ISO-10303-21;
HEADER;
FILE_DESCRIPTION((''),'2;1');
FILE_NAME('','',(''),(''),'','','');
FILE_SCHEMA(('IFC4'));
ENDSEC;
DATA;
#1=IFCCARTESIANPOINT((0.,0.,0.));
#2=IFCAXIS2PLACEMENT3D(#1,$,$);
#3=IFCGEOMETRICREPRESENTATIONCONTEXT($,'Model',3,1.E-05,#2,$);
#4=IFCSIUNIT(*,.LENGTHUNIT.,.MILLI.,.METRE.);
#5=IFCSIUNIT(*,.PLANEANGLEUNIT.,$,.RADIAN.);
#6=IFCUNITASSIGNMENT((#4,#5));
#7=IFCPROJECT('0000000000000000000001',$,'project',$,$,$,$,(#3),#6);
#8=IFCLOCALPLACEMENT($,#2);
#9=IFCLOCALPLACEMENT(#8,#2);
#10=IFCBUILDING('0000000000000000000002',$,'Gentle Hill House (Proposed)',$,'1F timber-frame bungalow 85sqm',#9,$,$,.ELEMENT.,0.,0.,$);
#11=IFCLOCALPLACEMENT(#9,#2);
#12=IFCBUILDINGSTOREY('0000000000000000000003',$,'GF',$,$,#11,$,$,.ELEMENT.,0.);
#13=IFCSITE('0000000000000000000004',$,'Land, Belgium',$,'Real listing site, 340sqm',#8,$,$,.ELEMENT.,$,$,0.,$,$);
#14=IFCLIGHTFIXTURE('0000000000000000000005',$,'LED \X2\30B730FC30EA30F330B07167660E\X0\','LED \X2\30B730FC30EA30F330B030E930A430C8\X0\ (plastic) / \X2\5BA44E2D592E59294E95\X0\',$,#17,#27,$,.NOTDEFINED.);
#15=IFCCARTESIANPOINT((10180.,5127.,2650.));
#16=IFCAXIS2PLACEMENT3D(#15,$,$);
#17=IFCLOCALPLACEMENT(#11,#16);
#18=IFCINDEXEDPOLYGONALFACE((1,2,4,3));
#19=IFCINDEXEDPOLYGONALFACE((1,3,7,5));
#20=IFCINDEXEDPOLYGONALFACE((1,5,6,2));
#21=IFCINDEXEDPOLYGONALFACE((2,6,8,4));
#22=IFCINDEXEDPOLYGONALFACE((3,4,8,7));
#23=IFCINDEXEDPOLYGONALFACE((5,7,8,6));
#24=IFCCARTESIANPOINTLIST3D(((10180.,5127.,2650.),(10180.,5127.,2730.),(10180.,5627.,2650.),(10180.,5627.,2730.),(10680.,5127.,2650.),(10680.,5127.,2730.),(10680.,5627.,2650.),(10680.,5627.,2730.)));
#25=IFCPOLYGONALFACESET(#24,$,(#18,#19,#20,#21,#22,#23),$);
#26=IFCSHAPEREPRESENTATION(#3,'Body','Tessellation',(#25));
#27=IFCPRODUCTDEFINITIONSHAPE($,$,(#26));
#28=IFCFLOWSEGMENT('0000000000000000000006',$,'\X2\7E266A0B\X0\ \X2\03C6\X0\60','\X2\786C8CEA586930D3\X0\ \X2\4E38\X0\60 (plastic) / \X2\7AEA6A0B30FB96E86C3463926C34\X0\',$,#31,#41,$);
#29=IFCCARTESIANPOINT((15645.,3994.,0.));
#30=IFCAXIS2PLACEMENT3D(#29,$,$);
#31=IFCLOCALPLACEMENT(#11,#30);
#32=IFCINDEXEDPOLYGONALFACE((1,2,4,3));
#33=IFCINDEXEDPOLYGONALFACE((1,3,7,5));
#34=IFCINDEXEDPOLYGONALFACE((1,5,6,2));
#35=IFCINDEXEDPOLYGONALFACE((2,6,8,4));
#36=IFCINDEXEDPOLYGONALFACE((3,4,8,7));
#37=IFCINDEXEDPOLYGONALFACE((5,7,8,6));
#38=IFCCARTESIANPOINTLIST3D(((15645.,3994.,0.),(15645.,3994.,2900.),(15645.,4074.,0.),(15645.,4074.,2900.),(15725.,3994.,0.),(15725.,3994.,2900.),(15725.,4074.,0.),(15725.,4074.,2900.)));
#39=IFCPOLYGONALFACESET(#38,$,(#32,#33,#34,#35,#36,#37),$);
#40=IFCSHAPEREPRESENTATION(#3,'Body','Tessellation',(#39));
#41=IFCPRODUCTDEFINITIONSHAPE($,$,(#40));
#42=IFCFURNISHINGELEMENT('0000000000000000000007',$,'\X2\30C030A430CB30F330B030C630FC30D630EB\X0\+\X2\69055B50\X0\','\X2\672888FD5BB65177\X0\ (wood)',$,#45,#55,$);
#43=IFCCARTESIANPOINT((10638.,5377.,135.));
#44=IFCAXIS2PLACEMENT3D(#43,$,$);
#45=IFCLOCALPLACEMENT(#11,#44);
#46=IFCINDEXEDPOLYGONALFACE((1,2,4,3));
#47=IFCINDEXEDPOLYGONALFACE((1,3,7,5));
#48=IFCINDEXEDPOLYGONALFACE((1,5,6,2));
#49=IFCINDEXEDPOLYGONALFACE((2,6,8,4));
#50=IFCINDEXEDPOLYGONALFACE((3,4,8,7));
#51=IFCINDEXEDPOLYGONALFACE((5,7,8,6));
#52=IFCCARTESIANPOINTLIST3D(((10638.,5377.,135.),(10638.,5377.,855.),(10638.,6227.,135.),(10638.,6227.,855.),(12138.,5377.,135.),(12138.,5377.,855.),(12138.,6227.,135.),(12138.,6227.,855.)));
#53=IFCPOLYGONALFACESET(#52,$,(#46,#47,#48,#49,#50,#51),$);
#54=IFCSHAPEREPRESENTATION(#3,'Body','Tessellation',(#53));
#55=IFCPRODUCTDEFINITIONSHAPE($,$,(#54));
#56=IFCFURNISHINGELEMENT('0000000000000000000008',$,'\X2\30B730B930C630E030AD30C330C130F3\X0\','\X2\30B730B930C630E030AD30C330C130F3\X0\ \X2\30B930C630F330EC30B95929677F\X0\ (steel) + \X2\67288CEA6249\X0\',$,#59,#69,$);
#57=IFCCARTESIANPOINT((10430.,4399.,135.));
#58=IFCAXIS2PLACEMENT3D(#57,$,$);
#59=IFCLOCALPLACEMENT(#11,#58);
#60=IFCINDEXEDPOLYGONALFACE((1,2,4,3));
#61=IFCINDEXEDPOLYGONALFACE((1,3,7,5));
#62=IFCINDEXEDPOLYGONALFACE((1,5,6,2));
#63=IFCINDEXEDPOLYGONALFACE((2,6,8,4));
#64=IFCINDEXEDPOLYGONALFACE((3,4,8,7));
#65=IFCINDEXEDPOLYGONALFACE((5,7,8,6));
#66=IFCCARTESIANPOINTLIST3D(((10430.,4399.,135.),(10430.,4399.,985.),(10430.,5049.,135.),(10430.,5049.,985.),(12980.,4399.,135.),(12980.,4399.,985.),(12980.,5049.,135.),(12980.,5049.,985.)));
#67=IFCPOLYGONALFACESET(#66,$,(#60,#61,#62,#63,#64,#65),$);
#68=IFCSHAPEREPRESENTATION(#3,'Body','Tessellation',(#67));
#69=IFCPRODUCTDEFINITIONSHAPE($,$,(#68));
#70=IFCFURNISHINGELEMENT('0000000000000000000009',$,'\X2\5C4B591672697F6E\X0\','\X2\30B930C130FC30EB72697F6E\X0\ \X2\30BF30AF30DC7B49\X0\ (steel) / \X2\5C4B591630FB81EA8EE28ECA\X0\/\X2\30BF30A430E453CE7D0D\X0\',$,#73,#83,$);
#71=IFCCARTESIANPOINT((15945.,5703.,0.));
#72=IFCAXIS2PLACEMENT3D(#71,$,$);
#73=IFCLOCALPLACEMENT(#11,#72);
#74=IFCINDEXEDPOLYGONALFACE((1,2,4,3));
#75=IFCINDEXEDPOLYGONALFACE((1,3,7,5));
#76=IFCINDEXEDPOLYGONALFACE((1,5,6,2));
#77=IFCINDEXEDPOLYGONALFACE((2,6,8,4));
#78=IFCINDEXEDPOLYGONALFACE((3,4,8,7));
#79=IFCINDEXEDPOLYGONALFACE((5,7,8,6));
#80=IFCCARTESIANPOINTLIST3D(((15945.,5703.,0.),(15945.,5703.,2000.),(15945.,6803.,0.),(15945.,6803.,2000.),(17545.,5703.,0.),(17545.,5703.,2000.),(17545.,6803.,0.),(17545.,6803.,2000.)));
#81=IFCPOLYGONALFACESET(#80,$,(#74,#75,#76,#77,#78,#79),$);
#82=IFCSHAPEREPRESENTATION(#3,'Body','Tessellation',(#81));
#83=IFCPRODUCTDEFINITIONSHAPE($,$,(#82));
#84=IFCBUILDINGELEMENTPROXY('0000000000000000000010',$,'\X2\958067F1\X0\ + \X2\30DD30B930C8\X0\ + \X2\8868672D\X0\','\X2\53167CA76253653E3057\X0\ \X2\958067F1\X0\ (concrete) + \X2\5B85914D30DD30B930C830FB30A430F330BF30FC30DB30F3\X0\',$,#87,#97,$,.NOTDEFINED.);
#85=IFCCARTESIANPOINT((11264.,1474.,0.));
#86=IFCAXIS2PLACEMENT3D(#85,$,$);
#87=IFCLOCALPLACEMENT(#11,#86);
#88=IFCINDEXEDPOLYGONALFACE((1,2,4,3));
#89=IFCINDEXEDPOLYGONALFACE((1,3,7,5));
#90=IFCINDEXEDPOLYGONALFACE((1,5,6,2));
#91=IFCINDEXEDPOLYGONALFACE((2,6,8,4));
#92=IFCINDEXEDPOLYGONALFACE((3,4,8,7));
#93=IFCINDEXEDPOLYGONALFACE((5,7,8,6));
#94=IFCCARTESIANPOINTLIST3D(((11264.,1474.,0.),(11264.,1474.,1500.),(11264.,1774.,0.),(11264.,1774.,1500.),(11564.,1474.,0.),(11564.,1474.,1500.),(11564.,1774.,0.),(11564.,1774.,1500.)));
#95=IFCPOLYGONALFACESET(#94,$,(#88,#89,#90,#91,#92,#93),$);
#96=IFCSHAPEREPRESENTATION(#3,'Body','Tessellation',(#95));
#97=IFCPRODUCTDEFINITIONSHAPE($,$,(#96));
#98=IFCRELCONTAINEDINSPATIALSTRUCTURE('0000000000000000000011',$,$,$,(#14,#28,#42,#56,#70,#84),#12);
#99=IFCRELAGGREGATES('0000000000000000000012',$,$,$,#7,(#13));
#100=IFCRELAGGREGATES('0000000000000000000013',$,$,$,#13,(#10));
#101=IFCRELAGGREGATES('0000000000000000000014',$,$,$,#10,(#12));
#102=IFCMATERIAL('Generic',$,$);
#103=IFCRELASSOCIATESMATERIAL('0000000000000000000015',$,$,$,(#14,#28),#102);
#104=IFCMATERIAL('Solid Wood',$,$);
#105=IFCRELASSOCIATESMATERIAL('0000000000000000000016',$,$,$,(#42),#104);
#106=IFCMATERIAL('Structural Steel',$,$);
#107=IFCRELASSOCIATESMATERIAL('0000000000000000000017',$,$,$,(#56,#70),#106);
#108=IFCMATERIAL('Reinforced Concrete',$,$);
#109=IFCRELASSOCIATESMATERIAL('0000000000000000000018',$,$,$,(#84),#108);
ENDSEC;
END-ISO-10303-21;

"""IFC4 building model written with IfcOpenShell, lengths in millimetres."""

from ifc_helpers import new_model, si_unit, frame, frame_2d, origin, place, context, project, spatial, rectangle, extrude, material, element, save


model = new_model("IFC4")

# Units and contexts
model_context = context("Model", 3, precision=1e-05, world=origin())
ifc_project = project(units=[si_unit("LENGTHUNIT", "METRE", prefix="MILLI"), si_unit("PLANEANGLEUNIT", "RADIAN")], contexts=[model_context])

# Site, building, storey
site_placement = place(None, origin())
site = spatial("IfcSite", under=ifc_project, at=site_placement, Name="Land, Belgium", ObjectType="Real listing site, 340sqm", CompositionType="ELEMENT", RefElevation=0.0)
building_placement = place(site_placement, origin())
building = spatial("IfcBuilding", under=site, at=building_placement, Name="Gentle Hill House (Proposed)", ObjectType="1F timber-frame bungalow 85sqm", CompositionType="ELEMENT", ElevationOfRefHeight=0.0, ElevationOfTerrain=0.0)
storey_placement = place(building_placement, origin())
storey = spatial("IfcBuildingStorey", under=building, at=storey_placement, Name="GF", CompositionType="ELEMENT", Elevation=0.0)

# Shared definitions
ifc_material_1 = material(Name="Solid Wood")

# Shared definitions
ifc_material_2 = material(Name="Structural Steel")

# Shared definitions
ifc_material_3 = material(Name="Reinforced Concrete")

# Shared definitions
ifc_material_4 = material(Name="Generic")

# Light fixture
light_fixture_placement = place(storey_placement, frame((10180.0, 5127.0, 2650.0)))
element("IfcLightFixture", 1, at=light_fixture_placement, inside=storey, material=ifc_material_4, Name="LED シーリング照明", Description="LED シーリングライト (plastic) / 室中央天井", PredefinedType="NOTDEFINED", context=model_context, shape_type="SweptSolid", body=[
    extrude(rectangle(XDim=500.0, YDim=500.0, at=frame_2d((250.0, 250.0))), frame((10180.0, 5127.0, 2650.0)), (0.0, 0.0, 1.0), 80.0),
])

# Flow segment
flow_segment_placement = place(storey_placement, frame((15645.0, 3994.0, 0.0)))
element("IfcFlowSegment", 2, at=flow_segment_placement, inside=storey, material=ifc_material_4, Name="縦樋 φ60", Description="硬質塩ビ 丸60 (plastic) / 竪樋・雨水排水", context=model_context, shape_type="SweptSolid", body=[
    extrude(rectangle(XDim=80.0, YDim=80.0, at=frame_2d((40.0, 40.0))), frame((15645.0, 3994.0, 0.0)), (0.0, 0.0, 1.0), 2900.0),
])

# Furnishing elements
furnishing_1_placement = place(storey_placement, frame((10638.0, 5377.0, 135.0)))
element("IfcFurnishingElement", 3, at=furnishing_1_placement, inside=storey, material=ifc_material_1, Name="ダイニングテーブル+椅子", Description="木製家具 (wood)", context=model_context, shape_type="SweptSolid", body=[
    extrude(rectangle(XDim=1500.0, YDim=850.0, at=frame_2d((750.0, 425.0))), frame((10638.0, 5377.0, 135.0)), (0.0, 0.0, 1.0), 720.0),
])
furnishing_2_placement = place(storey_placement, frame((10430.0, 4399.0, 135.0)))
element("IfcFurnishingElement", 4, at=furnishing_2_placement, inside=storey, material=ifc_material_2, Name="システムキッチン", Description="システムキッチン ステンレス天板 (steel) + 木質扉", context=model_context, shape_type="SweptSolid", body=[
    extrude(rectangle(XDim=2550.0, YDim=650.0, at=frame_2d((1275.0, 325.0))), frame((10430.0, 4399.0, 135.0)), (0.0, 0.0, 1.0), 850.0),
])
furnishing_3_placement = place(storey_placement, frame((15945.0, 5703.0, 0.0)))
element("IfcFurnishingElement", 5, at=furnishing_3_placement, inside=storey, material=ifc_material_2, Name="屋外物置", Description="スチール物置 タクボ等 (steel) / 屋外・自転車/タイヤ収納", context=model_context, shape_type="SweptSolid", body=[
    extrude(rectangle(XDim=1600.0, YDim=1100.0, at=frame_2d((800.0, 550.0))), frame((15945.0, 5703.0, 0.0)), (0.0, 0.0, 1.0), 2000.0),
])

# Building element proxy
proxy_placement = place(storey_placement, frame((11264.0, 1474.0, 0.0)))
element("IfcBuildingElementProxy", 6, at=proxy_placement, inside=storey, material=ifc_material_3, Name="門柱 + ポスト + 表札", Description="化粧打放し 門柱 (concrete) + 宅配ポスト・インターホン", PredefinedType="NOTDEFINED", context=model_context, shape_type="SweptSolid", body=[
    extrude(rectangle(XDim=300.0, YDim=300.0, at=frame_2d((150.0, 150.0))), frame((11264.0, 1474.0, 0.0)), (0.0, 0.0, 1.0), 1500.0),
])

save(model, "model.ifc")
